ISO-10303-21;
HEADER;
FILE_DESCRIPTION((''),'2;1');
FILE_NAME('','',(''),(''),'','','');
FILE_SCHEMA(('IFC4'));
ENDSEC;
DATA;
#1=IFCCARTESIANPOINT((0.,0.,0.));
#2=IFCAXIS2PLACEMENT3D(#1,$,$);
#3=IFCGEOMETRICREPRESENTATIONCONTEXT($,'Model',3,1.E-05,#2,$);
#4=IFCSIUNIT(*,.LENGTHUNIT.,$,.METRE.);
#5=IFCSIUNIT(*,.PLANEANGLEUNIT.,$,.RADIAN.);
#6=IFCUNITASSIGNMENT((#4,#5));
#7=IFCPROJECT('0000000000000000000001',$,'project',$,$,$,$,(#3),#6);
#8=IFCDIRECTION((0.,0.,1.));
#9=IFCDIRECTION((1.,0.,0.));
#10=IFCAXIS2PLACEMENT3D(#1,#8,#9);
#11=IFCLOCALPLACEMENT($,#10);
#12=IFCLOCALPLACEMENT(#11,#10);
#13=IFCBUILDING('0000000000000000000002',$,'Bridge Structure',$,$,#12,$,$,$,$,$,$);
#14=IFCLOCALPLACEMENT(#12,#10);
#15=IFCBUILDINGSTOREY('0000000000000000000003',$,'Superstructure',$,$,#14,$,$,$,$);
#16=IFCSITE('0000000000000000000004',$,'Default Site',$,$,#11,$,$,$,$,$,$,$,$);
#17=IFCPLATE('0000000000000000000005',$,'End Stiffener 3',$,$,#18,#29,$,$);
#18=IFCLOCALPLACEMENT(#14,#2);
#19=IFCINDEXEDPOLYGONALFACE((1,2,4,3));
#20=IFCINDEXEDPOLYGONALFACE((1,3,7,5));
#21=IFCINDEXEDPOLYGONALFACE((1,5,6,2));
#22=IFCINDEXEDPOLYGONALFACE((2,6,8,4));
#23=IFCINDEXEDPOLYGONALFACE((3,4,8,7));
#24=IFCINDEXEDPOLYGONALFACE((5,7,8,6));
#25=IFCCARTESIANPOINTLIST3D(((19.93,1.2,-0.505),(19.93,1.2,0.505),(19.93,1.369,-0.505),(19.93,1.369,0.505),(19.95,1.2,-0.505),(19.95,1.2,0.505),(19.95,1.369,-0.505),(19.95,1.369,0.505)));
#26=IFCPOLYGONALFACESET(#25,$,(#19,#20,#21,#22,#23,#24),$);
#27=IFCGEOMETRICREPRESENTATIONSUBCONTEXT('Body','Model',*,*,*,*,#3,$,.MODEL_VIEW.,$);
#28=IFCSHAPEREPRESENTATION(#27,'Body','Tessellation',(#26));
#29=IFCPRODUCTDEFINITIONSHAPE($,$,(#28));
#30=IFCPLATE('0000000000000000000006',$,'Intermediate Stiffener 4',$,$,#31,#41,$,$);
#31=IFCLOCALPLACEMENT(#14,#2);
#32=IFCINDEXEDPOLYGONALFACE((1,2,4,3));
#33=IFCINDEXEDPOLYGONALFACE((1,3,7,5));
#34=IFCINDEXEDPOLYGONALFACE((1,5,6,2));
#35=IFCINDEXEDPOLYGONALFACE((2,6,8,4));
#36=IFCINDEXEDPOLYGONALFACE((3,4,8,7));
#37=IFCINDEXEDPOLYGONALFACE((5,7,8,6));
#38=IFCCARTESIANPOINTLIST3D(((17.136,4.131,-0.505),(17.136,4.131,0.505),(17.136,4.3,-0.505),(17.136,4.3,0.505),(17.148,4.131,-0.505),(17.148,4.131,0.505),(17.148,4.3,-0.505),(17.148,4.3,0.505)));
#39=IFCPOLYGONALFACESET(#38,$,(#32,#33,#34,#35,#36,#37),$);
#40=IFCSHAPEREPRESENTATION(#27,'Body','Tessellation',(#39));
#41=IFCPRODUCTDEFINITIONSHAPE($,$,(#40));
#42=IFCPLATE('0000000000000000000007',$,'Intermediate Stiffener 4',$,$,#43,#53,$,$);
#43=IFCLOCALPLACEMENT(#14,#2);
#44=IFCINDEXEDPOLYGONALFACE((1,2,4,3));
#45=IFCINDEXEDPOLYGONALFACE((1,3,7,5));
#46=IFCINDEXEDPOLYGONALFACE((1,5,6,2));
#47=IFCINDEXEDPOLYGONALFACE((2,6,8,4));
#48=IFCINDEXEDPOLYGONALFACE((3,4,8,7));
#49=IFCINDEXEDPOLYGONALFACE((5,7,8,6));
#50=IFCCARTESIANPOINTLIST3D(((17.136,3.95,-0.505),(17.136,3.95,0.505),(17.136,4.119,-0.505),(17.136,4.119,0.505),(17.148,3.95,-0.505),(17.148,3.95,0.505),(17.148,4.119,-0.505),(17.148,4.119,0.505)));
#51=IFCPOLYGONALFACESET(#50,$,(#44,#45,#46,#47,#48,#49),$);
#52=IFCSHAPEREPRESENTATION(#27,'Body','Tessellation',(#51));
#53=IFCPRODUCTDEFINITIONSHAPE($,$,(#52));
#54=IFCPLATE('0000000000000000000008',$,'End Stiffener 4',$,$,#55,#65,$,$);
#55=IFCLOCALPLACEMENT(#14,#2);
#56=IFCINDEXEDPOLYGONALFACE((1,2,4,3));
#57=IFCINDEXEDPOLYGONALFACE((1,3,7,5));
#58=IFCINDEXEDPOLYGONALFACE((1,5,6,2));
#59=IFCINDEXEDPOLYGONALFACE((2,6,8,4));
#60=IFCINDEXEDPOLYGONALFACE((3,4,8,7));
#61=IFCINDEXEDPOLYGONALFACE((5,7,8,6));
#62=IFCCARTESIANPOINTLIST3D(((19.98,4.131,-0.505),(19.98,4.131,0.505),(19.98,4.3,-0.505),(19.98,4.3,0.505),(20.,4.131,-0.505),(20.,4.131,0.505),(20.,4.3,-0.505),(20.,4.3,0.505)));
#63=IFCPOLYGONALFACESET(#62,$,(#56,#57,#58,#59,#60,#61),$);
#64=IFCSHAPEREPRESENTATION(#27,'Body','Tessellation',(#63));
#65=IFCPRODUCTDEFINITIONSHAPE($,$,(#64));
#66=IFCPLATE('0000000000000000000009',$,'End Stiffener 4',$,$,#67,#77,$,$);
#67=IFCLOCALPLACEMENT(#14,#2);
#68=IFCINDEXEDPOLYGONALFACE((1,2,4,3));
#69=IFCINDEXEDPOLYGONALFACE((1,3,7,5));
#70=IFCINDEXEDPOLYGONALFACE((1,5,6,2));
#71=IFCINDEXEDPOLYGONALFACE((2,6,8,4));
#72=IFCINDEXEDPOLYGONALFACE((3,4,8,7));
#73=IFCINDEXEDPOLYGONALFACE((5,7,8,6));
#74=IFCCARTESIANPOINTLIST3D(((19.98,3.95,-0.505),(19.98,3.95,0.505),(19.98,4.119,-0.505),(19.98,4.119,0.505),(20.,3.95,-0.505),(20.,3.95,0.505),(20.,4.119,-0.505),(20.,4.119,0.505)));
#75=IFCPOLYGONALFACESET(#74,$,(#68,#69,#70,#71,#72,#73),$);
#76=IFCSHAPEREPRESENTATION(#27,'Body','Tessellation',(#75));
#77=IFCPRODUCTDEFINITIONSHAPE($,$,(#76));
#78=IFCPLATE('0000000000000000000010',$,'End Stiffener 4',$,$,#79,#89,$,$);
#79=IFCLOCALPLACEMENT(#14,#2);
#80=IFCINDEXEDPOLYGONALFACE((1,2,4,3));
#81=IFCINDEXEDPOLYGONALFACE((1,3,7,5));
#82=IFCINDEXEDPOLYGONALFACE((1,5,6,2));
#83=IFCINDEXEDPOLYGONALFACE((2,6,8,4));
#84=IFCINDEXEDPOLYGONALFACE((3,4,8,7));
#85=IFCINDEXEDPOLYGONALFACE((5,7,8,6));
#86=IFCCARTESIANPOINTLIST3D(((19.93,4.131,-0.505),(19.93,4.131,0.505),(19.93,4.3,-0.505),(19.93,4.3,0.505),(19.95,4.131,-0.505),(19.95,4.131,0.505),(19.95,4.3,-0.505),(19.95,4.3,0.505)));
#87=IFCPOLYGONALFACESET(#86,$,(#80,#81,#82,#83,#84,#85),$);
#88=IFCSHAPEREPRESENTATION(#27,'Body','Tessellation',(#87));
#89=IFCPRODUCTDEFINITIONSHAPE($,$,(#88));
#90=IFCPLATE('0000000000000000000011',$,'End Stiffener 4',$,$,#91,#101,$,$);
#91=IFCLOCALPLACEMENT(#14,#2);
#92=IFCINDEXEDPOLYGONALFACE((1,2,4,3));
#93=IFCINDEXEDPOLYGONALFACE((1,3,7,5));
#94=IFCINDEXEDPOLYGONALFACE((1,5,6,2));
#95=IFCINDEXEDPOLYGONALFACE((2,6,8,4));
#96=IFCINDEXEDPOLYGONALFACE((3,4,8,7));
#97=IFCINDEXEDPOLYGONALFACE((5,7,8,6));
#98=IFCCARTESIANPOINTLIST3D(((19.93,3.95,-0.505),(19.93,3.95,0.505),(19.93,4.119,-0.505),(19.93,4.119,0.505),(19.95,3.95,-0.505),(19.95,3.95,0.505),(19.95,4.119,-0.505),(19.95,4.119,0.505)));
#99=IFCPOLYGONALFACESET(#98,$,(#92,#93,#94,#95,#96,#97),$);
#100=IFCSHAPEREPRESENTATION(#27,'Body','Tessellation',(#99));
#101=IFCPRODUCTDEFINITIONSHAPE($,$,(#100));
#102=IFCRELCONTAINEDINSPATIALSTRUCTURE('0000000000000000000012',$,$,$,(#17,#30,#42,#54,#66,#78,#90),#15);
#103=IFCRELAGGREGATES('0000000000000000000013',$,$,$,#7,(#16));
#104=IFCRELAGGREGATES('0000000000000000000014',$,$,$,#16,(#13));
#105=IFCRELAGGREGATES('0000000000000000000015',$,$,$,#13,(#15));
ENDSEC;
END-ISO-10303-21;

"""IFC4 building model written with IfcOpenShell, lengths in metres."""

from ifc_helpers import new_model, si_unit, frame, origin, origin_with_axes, origin_2d_with_axis, place, context, subcontext, project, spatial, rectangle, extrude, element, save


model = new_model("IFC4")

# Units and contexts
model_context = context("Model", 3, precision=1e-05, world=origin())
body_context = subcontext(model_context, "Body", "Model", "MODEL_VIEW")
ifc_project = project(units=[si_unit("LENGTHUNIT", "METRE"), si_unit("PLANEANGLEUNIT", "RADIAN")], contexts=[model_context])

# Site, building, storey
site_placement = place(None, origin_with_axes())
site = spatial("IfcSite", under=ifc_project, at=site_placement, Name="Default Site")
building_placement = place(site_placement, origin_with_axes())
building = spatial("IfcBuilding", under=site, at=building_placement, Name="Bridge Structure")
storey_placement = place(building_placement, origin_with_axes())
storey = spatial("IfcBuildingStorey", under=building, at=storey_placement, Name="Superstructure")

# Plates
for number, where, z_axis, x_axis, name in (
    (1, (19.94, 1.2845, -0.505), (0.0, 0.0, 1.0), (1.0, 0.0, 0.0), "End Stiffener 3"),
):
    element("IfcPlate", number, at=place(storey_placement, frame(where, z_axis=z_axis, x_axis=x_axis)), inside=storey, Name=name, context=body_context, shape_type="SweptSolid", body=[
        extrude(rectangle(XDim=0.02, YDim=0.169, at=origin_2d_with_axis()), origin_with_axes(), (0.0, 0.0, 1.0), 1.01),
    ])
for number, where, z_axis, x_axis, name in (
    (2, (17.142, 4.2155, -0.505), (0.0, 0.0, 1.0), (1.0, 0.0, 0.0), "Intermediate Stiffener 4"),
    (3, (17.142, 4.0345, -0.505), (0.0, 0.0, 1.0), (1.0, 0.0, 0.0), "Intermediate Stiffener 4"),
):
    element("IfcPlate", number, at=place(storey_placement, frame(where, z_axis=z_axis, x_axis=x_axis)), inside=storey, Name=name, context=body_context, shape_type="SweptSolid", body=[
        extrude(rectangle(XDim=0.012, YDim=0.169, at=origin_2d_with_axis()), origin_with_axes(), (0.0, 0.0, 1.0), 1.01),
    ])
for number, where, z_axis, x_axis, name in (
    (4, (19.99, 4.2155, -0.505), (0.0, 0.0, 1.0), (1.0, 0.0, 0.0), "End Stiffener 4"),
    (5, (19.99, 4.0345, -0.505), (0.0, 0.0, 1.0), (1.0, 0.0, 0.0), "End Stiffener 4"),
    (6, (19.94, 4.2155, -0.505), (0.0, 0.0, 1.0), (1.0, 0.0, 0.0), "End Stiffener 4"),
    (7, (19.94, 4.0345, -0.505), (0.0, 0.0, 1.0), (1.0, 0.0, 0.0), "End Stiffener 4"),
):
    element("IfcPlate", number, at=place(storey_placement, frame(where, z_axis=z_axis, x_axis=x_axis)), inside=storey, Name=name, context=body_context, shape_type="SweptSolid", body=[
        extrude(rectangle(XDim=0.02, YDim=0.169, at=origin_2d_with_axis()), origin_with_axes(), (0.0, 0.0, 1.0), 1.01),
    ])

save(model, "model.ifc")
